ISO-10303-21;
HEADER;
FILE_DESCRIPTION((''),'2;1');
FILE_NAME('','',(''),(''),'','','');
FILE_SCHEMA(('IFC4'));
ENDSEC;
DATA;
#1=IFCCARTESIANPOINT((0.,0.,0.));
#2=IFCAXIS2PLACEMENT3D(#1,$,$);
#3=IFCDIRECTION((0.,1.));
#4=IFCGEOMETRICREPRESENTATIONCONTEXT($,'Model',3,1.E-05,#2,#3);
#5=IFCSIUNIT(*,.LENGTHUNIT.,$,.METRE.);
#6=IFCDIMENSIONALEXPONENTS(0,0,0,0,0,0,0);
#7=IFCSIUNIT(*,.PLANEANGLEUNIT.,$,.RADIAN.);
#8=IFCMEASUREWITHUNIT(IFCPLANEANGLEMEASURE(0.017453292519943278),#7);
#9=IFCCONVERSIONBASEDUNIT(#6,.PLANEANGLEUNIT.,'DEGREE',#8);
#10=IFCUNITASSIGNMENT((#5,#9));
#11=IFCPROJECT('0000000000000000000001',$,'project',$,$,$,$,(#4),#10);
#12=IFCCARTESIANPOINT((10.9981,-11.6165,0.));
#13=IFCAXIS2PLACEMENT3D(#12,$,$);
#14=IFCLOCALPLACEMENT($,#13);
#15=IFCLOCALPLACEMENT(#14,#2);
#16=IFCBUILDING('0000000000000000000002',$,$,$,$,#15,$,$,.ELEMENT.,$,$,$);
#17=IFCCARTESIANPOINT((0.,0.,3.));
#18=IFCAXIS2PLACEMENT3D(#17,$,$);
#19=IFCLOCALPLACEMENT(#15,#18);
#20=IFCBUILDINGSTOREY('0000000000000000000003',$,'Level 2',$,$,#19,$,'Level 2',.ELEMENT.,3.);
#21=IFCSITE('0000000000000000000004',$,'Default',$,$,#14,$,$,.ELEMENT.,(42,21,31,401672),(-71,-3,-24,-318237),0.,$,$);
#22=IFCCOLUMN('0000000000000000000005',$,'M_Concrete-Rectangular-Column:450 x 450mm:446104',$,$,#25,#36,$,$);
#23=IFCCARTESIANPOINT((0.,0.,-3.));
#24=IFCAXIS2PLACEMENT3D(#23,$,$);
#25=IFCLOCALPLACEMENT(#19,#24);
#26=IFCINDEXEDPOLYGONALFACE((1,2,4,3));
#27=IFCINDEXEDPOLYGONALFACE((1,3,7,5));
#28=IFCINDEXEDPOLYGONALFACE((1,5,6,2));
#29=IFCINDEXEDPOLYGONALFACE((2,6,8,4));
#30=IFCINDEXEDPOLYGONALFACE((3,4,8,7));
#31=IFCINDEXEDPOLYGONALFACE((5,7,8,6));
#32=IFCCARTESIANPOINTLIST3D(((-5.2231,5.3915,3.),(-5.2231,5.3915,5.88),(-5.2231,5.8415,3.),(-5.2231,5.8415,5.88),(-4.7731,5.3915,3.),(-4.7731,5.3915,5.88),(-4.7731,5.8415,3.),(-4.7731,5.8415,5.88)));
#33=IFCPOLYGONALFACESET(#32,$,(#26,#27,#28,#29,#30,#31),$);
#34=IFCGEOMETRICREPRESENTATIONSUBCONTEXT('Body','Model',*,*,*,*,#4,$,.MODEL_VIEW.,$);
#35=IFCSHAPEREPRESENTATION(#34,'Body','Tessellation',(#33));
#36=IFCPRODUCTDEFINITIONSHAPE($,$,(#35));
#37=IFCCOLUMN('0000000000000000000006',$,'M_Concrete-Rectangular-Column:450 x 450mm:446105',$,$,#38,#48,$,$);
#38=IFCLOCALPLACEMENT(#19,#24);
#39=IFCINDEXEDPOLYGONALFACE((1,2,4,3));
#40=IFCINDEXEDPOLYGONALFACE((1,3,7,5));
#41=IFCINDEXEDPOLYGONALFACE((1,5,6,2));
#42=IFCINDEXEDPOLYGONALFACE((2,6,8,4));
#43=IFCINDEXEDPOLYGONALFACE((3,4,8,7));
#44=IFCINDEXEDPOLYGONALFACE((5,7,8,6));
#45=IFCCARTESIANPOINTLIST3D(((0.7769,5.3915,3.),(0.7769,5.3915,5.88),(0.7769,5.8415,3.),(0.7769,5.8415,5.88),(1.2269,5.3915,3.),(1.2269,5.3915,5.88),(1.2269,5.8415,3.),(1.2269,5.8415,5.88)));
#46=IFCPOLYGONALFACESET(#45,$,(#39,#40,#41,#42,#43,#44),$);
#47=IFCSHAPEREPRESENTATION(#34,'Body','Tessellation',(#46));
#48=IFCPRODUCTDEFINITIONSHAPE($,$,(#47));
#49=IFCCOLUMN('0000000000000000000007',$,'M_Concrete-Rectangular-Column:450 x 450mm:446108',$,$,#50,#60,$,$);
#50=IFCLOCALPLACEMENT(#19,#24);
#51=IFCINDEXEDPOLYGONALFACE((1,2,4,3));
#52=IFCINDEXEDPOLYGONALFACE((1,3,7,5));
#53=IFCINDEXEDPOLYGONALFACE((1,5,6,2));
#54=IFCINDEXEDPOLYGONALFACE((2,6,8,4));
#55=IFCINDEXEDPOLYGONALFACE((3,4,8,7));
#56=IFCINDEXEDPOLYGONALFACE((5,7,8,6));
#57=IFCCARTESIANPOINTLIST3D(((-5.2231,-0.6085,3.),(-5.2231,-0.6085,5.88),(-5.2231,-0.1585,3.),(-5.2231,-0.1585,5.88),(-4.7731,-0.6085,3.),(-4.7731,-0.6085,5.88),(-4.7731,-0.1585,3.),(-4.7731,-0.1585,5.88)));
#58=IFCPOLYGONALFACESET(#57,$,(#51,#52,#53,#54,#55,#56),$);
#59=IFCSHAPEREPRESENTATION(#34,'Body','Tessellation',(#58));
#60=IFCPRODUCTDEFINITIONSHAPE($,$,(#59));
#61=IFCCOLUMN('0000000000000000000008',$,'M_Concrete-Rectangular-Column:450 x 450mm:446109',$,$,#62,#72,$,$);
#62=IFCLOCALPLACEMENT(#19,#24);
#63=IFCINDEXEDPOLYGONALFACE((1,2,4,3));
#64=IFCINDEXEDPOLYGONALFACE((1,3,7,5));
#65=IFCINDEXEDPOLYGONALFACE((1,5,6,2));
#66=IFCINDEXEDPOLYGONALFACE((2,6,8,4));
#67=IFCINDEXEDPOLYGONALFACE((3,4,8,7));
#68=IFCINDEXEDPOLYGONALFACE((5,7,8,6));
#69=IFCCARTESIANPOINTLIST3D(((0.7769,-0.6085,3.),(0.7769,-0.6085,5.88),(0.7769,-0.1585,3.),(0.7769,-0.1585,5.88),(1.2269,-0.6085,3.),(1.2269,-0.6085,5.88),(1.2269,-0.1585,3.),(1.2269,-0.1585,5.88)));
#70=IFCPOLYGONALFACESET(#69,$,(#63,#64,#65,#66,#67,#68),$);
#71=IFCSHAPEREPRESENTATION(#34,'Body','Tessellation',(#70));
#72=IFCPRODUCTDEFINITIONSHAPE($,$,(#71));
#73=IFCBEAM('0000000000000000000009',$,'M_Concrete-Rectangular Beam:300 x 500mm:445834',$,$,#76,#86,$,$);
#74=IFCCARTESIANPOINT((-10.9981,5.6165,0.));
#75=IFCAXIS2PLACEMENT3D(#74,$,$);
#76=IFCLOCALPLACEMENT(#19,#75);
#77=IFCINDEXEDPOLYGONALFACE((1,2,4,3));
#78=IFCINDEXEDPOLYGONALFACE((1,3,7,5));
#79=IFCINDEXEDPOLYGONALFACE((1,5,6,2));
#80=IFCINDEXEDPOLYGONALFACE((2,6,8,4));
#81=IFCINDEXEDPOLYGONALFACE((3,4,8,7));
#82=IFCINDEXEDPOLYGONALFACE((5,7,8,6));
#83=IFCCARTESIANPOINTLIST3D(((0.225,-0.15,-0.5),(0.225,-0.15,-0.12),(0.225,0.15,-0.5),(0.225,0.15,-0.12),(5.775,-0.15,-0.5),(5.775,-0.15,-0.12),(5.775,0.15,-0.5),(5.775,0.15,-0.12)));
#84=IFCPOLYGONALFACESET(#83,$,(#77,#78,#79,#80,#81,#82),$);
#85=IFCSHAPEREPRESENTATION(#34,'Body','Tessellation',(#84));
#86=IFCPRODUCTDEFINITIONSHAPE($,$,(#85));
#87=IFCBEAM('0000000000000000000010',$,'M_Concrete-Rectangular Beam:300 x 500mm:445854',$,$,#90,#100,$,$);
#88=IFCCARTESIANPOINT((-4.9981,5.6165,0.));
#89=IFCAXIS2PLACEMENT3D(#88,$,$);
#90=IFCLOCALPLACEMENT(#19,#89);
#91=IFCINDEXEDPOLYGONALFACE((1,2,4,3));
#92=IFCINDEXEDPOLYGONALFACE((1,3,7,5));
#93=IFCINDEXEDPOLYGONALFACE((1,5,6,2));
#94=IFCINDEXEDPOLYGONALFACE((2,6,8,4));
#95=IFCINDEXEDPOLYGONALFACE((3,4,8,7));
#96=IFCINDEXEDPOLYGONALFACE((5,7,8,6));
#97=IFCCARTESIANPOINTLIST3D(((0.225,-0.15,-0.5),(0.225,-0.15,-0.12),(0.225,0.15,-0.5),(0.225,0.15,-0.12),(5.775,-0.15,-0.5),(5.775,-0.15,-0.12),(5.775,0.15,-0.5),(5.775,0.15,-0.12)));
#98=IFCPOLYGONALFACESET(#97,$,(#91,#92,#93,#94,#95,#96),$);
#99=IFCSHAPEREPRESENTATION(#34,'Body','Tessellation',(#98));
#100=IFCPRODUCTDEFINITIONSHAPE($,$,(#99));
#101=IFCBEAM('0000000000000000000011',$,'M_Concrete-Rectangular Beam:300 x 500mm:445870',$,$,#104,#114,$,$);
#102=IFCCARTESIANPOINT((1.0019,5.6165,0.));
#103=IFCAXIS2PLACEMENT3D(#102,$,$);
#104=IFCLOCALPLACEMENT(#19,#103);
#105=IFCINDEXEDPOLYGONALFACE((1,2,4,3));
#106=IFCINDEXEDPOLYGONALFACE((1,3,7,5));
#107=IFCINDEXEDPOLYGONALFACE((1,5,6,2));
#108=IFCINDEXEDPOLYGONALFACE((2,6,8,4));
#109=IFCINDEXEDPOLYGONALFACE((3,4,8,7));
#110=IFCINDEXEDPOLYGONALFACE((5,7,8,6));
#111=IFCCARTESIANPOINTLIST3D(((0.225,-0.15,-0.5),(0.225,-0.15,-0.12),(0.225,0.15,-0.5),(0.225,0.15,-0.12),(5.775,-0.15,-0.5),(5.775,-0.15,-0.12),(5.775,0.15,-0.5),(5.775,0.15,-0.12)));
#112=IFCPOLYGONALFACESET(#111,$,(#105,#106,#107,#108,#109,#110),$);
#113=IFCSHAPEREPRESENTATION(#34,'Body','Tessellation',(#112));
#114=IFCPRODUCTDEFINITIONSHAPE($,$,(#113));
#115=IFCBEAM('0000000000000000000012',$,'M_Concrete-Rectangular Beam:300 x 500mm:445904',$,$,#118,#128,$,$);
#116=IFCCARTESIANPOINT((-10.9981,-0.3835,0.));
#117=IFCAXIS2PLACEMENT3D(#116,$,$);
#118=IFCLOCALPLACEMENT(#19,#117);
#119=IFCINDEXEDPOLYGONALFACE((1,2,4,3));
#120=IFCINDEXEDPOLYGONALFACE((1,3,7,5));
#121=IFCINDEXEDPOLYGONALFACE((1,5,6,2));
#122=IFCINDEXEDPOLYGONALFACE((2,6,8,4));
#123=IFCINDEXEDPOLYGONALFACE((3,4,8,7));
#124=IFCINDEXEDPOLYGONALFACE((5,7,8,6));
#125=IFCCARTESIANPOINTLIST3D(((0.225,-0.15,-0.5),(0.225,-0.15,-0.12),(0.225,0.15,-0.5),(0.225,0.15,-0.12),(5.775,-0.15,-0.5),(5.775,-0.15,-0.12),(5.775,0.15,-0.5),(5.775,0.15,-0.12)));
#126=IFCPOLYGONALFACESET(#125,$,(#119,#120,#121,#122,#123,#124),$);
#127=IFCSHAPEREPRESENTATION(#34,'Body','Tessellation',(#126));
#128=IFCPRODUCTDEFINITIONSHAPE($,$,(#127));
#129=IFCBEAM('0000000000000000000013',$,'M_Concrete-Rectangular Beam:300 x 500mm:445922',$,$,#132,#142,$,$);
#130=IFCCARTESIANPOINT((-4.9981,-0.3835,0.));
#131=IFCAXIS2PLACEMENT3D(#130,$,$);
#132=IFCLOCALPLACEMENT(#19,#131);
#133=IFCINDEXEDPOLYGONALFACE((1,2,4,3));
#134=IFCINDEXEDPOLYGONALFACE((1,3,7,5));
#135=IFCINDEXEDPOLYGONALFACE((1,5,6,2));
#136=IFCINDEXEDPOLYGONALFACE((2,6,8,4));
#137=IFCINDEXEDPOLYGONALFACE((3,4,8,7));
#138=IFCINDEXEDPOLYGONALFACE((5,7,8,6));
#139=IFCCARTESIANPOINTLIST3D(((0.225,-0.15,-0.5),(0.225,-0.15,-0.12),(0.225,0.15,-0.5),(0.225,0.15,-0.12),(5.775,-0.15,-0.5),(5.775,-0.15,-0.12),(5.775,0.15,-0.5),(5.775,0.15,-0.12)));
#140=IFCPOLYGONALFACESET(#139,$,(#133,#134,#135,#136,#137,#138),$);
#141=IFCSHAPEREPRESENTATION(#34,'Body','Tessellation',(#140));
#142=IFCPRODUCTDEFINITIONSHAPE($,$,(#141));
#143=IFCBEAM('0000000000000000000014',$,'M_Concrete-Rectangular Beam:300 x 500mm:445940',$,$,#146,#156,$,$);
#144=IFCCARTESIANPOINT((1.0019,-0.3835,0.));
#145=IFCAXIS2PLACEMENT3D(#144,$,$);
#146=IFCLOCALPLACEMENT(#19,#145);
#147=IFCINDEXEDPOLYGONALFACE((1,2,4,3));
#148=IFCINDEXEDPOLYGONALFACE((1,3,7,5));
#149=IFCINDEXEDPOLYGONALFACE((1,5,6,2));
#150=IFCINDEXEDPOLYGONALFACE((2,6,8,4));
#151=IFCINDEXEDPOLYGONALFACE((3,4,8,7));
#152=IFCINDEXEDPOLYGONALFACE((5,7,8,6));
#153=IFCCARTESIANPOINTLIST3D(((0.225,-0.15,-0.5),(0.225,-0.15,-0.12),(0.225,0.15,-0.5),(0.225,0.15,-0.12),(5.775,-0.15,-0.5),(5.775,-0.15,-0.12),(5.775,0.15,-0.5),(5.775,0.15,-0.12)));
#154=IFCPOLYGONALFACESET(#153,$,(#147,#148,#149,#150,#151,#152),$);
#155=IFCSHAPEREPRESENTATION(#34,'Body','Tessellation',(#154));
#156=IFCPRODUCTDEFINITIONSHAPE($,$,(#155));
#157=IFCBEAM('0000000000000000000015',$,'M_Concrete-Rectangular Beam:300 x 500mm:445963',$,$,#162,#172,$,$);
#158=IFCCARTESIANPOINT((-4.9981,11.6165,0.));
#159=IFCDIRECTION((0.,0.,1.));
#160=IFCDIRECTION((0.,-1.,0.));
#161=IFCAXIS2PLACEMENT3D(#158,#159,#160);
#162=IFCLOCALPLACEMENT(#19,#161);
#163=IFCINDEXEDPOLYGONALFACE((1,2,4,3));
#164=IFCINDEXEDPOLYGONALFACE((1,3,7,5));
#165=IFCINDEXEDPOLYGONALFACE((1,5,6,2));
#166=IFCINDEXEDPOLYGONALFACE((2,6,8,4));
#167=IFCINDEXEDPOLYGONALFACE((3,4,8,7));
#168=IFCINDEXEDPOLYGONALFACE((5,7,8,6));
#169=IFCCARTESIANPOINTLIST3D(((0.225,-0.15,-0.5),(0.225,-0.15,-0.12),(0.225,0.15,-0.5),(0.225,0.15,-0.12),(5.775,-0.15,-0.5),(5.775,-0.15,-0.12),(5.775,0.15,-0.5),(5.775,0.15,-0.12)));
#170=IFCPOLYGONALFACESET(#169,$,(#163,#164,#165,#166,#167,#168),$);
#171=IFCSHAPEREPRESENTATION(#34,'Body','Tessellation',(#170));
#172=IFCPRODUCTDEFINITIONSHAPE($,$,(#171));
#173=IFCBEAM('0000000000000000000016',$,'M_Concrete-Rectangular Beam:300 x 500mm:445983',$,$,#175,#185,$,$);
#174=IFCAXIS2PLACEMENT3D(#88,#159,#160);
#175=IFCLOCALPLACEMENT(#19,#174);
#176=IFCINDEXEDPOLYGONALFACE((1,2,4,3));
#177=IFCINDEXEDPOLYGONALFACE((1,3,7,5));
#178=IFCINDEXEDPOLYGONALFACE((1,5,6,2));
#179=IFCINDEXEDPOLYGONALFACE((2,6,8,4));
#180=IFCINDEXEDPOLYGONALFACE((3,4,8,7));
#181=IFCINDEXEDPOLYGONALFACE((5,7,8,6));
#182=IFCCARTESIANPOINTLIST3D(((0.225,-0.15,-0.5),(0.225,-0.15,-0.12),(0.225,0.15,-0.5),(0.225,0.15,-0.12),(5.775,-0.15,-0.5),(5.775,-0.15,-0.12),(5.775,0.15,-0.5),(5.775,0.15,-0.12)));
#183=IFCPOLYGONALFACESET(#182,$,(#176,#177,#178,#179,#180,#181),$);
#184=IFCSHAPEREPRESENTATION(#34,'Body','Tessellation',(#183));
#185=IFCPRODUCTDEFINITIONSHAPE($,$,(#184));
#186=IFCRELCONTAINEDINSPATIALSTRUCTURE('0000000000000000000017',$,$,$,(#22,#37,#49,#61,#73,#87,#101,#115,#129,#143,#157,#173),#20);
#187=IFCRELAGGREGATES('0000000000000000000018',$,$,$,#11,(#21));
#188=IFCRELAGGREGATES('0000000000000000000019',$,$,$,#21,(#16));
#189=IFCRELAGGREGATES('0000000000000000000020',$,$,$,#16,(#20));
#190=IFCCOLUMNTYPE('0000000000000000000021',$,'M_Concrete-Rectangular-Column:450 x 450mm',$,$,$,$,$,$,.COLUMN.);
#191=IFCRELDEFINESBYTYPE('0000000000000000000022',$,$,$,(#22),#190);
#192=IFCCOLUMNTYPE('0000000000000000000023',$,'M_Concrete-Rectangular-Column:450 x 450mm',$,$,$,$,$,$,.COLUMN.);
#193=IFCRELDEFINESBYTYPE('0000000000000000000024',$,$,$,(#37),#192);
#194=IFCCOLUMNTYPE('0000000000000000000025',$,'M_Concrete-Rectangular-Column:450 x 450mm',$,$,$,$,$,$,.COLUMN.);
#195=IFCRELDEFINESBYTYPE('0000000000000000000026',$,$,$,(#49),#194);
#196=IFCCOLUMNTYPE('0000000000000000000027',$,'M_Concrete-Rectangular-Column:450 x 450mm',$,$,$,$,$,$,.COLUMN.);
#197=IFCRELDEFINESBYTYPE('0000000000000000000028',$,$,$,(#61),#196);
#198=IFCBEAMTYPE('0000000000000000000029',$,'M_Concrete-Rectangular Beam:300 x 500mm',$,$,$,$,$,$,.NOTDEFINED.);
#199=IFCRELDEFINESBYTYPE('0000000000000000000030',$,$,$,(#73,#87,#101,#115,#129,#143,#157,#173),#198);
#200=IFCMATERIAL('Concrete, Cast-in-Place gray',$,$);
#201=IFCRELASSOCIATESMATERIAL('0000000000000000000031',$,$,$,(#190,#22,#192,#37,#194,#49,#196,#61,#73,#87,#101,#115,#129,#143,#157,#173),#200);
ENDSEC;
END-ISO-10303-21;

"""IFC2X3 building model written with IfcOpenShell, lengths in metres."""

from ifc_helpers import new_model, entity, si_unit, converted_unit, direction, frame, frame_2d, origin, place, context, subcontext, project, spatial, rectangle, extrude, source, transform, mapped, material, type_object, type_shapes, element, save


model = new_model("IFC2X3")

# Units and contexts
model_context = context("Model", 3, precision=1e-05, world=origin(), true_north=direction((0.0, 1.0)))
body_context = subcontext(model_context, "Body", "Model", "MODEL_VIEW")
ifc_project = project(units=[si_unit("LENGTHUNIT", "METRE"), converted_unit("PLANEANGLEUNIT", "DEGREE", entity("IfcPlaneAngleMeasure", 0.017453292519943278), si_unit("PLANEANGLEUNIT", "RADIAN"), dimensions=[0, 0, 0, 0, 0, 0, 0])], contexts=[model_context])

# Site, building, storey
site_placement = place(None, frame((10.9981, -11.6165, 0.0)))
site = spatial("IfcSite", under=ifc_project, at=site_placement, Name="Default", CompositionType="ELEMENT", RefLatitude=(42, 21, 31, 401672), RefLongitude=(-71, -3, -24, -318237), RefElevation=0.0)
building_placement = place(site_placement, origin())
building = spatial("IfcBuilding", under=site, at=building_placement, CompositionType="ELEMENT")
storey_placement = place(building_placement, frame((0.0, 0.0, 3.0)))
storey = spatial("IfcBuildingStorey", under=building, at=storey_placement, Name="Level 2", LongName="Level 2", CompositionType="ELEMENT", Elevation=3.0)

# Columns
ifc_material_1 = material(Name="Concrete, Cast-in-Place gray")
column_type_1 = type_object("IfcColumnType", Name="M_Concrete-Rectangular-Column:450 x 450mm", PredefinedType="COLUMN", material=ifc_material_1)
shared_shape_1 = source(origin(), body_context, "Body", "SweptSolid", [
    extrude(rectangle(XDim=0.45, YDim=0.45, at=frame_2d((0.0, 0.0), x_axis=(1.0, 0.0))), frame((-4.9981, 5.6165, 3.0), z_axis=(0.0, 0.0, 1.0), x_axis=(-1.0, 0.0, 0.0)), (0.0, 0.0, 1.0), 2.88),
])
type_shapes(column_type_1, [shared_shape_1])
column_1_placement = place(storey_placement, frame((0.0, 0.0, -3.0)))
element("IfcColumn", 1, at=column_1_placement, inside=storey, type_object=column_type_1, material=ifc_material_1, Name="M_Concrete-Rectangular-Column:450 x 450mm:446104", context=body_context, shape_type="MappedRepresentation", body=[
    mapped(shared_shape_1, transform((0.0, 0.0, 0.0), scale=1.0)),
])
column_type_2 = type_object("IfcColumnType", Name="M_Concrete-Rectangular-Column:450 x 450mm", PredefinedType="COLUMN", material=ifc_material_1)
shared_shape_2 = source(origin(), body_context, "Body", "SweptSolid", [
    extrude(rectangle(XDim=0.45, YDim=0.45, at=frame_2d((0.0, 0.0), x_axis=(1.0, 0.0))), frame((1.0019, 5.6165, 3.0), z_axis=(0.0, 0.0, 1.0), x_axis=(-1.0, 0.0, 0.0)), (0.0, 0.0, 1.0), 2.88),
])
type_shapes(column_type_2, [shared_shape_2])
column_2_placement = place(storey_placement, frame((0.0, 0.0, -3.0)))
element("IfcColumn", 2, at=column_2_placement, inside=storey, type_object=column_type_2, material=ifc_material_1, Name="M_Concrete-Rectangular-Column:450 x 450mm:446105", context=body_context, shape_type="MappedRepresentation", body=[
    mapped(shared_shape_2, transform((0.0, 0.0, 0.0), scale=1.0)),
])
column_type_3 = type_object("IfcColumnType", Name="M_Concrete-Rectangular-Column:450 x 450mm", PredefinedType="COLUMN", material=ifc_material_1)
shared_shape_3 = source(origin(), body_context, "Body", "SweptSolid", [
    extrude(rectangle(XDim=0.45, YDim=0.45, at=frame_2d((0.0, 0.0), x_axis=(1.0, 0.0))), frame((-4.9981, -0.3835, 3.0), z_axis=(0.0, 0.0, 1.0), x_axis=(-1.0, 0.0, 0.0)), (0.0, 0.0, 1.0), 2.88),
])
type_shapes(column_type_3, [shared_shape_3])
column_3_placement = place(storey_placement, frame((0.0, 0.0, -3.0)))
element("IfcColumn", 3, at=column_3_placement, inside=storey, type_object=column_type_3, material=ifc_material_1, Name="M_Concrete-Rectangular-Column:450 x 450mm:446108", context=body_context, shape_type="MappedRepresentation", body=[
    mapped(shared_shape_3, transform((0.0, 0.0, 0.0), scale=1.0)),
])
column_type_4 = type_object("IfcColumnType", Name="M_Concrete-Rectangular-Column:450 x 450mm", PredefinedType="COLUMN", material=ifc_material_1)
shared_shape_4 = source(origin(), body_context, "Body", "SweptSolid", [
    extrude(rectangle(XDim=0.45, YDim=0.45, at=frame_2d((0.0, 0.0), x_axis=(1.0, 0.0))), frame((1.0019, -0.3835, 3.0), z_axis=(0.0, 0.0, 1.0), x_axis=(-1.0, 0.0, 0.0)), (0.0, 0.0, 1.0), 2.88),
])
type_shapes(column_type_4, [shared_shape_4])
column_4_placement = place(storey_placement, frame((0.0, 0.0, -3.0)))
element("IfcColumn", 4, at=column_4_placement, inside=storey, type_object=column_type_4, material=ifc_material_1, Name="M_Concrete-Rectangular-Column:450 x 450mm:446109", context=body_context, shape_type="MappedRepresentation", body=[
    mapped(shared_shape_4, transform((0.0, 0.0, 0.0), scale=1.0)),
])

# Beams
beam_type = type_object("IfcBeamType", Name="M_Concrete-Rectangular Beam:300 x 500mm", PredefinedType="NOTDEFINED")
beam_1_placement = place(storey_placement, frame((-10.9981, 5.6165, 0.0)))
element("IfcBeam", 5, at=beam_1_placement, inside=storey, type_object=beam_type, material=ifc_material_1, Name="M_Concrete-Rectangular Beam:300 x 500mm:445834", context=body_context, shape_type="SweptSolid", body=[
    extrude(rectangle(XDim=0.38, YDim=0.3, at=frame_2d((0.0, 0.0), x_axis=(1.0, 0.0))), frame((0.225, 0.0, -0.31), z_axis=(1.0, 0.0, 0.0), x_axis=(0.0, 0.0, -1.0)), (0.0, 0.0, 1.0), 5.55),
])
beam_2_placement = place(storey_placement, frame((-4.9981, 5.6165, 0.0)))
element("IfcBeam", 6, at=beam_2_placement, inside=storey, type_object=beam_type, material=ifc_material_1, Name="M_Concrete-Rectangular Beam:300 x 500mm:445854", context=body_context, shape_type="SweptSolid", body=[
    extrude(rectangle(XDim=0.38, YDim=0.3, at=frame_2d((0.0, 0.0), x_axis=(1.0, 0.0))), frame((0.225, 0.0, -0.31), z_axis=(1.0, 0.0, 0.0), x_axis=(0.0, 0.0, -1.0)), (0.0, 0.0, 1.0), 5.55),
])
beam_3_placement = place(storey_placement, frame((1.0019, 5.6165, 0.0)))
element("IfcBeam", 7, at=beam_3_placement, inside=storey, type_object=beam_type, material=ifc_material_1, Name="M_Concrete-Rectangular Beam:300 x 500mm:445870", context=body_context, shape_type="SweptSolid", body=[
    extrude(rectangle(XDim=0.38, YDim=0.3, at=frame_2d((0.0, 0.0), x_axis=(1.0, 0.0))), frame((0.225, 0.0, -0.31), z_axis=(1.0, 0.0, 0.0), x_axis=(0.0, 0.0, -1.0)), (0.0, 0.0, 1.0), 5.55),
])
beam_4_placement = place(storey_placement, frame((-10.9981, -0.3835, 0.0)))
element("IfcBeam", 8, at=beam_4_placement, inside=storey, type_object=beam_type, material=ifc_material_1, Name="M_Concrete-Rectangular Beam:300 x 500mm:445904", context=body_context, shape_type="SweptSolid", body=[
    extrude(rectangle(XDim=0.38, YDim=0.3, at=frame_2d((0.0, 0.0), x_axis=(1.0, 0.0))), frame((0.225, 0.0, -0.31), z_axis=(1.0, 0.0, 0.0), x_axis=(0.0, 0.0, -1.0)), (0.0, 0.0, 1.0), 5.55),
])
beam_5_placement = place(storey_placement, frame((-4.9981, -0.3835, 0.0)))
element("IfcBeam", 9, at=beam_5_placement, inside=storey, type_object=beam_type, material=ifc_material_1, Name="M_Concrete-Rectangular Beam:300 x 500mm:445922", context=body_context, shape_type="SweptSolid", body=[
    extrude(rectangle(XDim=0.38, YDim=0.3, at=frame_2d((0.0, 0.0), x_axis=(1.0, 0.0))), frame((0.225, 0.0, -0.31), z_axis=(1.0, 0.0, 0.0), x_axis=(0.0, 0.0, -1.0)), (0.0, 0.0, 1.0), 5.55),
])
beam_6_placement = place(storey_placement, frame((1.0019, -0.3835, 0.0)))
element("IfcBeam", 10, at=beam_6_placement, inside=storey, type_object=beam_type, material=ifc_material_1, Name="M_Concrete-Rectangular Beam:300 x 500mm:445940", context=body_context, shape_type="SweptSolid", body=[
    extrude(rectangle(XDim=0.38, YDim=0.3, at=frame_2d((0.0, 0.0), x_axis=(1.0, 0.0))), frame((0.225, 0.0, -0.31), z_axis=(1.0, 0.0, 0.0), x_axis=(0.0, 0.0, -1.0)), (0.0, 0.0, 1.0), 5.55),
])
beam_7_placement = place(storey_placement, frame((-4.9981, 11.6165, 0.0), z_axis=(0.0, 0.0, 1.0), x_axis=(0.0, -1.0, 0.0)))
element("IfcBeam", 11, at=beam_7_placement, inside=storey, type_object=beam_type, material=ifc_material_1, Name="M_Concrete-Rectangular Beam:300 x 500mm:445963", context=body_context, shape_type="SweptSolid", body=[
    extrude(rectangle(XDim=0.38, YDim=0.3, at=frame_2d((0.0, 0.0), x_axis=(1.0, 0.0))), frame((0.225, 0.0, -0.31), z_axis=(1.0, 0.0, 0.0), x_axis=(0.0, 0.0, -1.0)), (0.0, 0.0, 1.0), 5.55),
])
beam_8_placement = place(storey_placement, frame((-4.9981, 5.6165, 0.0), z_axis=(0.0, 0.0, 1.0), x_axis=(0.0, -1.0, 0.0)))
element("IfcBeam", 12, at=beam_8_placement, inside=storey, type_object=beam_type, material=ifc_material_1, Name="M_Concrete-Rectangular Beam:300 x 500mm:445983", context=body_context, shape_type="SweptSolid", body=[
    extrude(rectangle(XDim=0.38, YDim=0.3, at=frame_2d((0.0, 0.0), x_axis=(1.0, 0.0))), frame((0.225, 0.0, -0.31), z_axis=(1.0, 0.0, 0.0), x_axis=(0.0, 0.0, -1.0)), (0.0, 0.0, 1.0), 5.55),
])

save(model, "model.ifc")
